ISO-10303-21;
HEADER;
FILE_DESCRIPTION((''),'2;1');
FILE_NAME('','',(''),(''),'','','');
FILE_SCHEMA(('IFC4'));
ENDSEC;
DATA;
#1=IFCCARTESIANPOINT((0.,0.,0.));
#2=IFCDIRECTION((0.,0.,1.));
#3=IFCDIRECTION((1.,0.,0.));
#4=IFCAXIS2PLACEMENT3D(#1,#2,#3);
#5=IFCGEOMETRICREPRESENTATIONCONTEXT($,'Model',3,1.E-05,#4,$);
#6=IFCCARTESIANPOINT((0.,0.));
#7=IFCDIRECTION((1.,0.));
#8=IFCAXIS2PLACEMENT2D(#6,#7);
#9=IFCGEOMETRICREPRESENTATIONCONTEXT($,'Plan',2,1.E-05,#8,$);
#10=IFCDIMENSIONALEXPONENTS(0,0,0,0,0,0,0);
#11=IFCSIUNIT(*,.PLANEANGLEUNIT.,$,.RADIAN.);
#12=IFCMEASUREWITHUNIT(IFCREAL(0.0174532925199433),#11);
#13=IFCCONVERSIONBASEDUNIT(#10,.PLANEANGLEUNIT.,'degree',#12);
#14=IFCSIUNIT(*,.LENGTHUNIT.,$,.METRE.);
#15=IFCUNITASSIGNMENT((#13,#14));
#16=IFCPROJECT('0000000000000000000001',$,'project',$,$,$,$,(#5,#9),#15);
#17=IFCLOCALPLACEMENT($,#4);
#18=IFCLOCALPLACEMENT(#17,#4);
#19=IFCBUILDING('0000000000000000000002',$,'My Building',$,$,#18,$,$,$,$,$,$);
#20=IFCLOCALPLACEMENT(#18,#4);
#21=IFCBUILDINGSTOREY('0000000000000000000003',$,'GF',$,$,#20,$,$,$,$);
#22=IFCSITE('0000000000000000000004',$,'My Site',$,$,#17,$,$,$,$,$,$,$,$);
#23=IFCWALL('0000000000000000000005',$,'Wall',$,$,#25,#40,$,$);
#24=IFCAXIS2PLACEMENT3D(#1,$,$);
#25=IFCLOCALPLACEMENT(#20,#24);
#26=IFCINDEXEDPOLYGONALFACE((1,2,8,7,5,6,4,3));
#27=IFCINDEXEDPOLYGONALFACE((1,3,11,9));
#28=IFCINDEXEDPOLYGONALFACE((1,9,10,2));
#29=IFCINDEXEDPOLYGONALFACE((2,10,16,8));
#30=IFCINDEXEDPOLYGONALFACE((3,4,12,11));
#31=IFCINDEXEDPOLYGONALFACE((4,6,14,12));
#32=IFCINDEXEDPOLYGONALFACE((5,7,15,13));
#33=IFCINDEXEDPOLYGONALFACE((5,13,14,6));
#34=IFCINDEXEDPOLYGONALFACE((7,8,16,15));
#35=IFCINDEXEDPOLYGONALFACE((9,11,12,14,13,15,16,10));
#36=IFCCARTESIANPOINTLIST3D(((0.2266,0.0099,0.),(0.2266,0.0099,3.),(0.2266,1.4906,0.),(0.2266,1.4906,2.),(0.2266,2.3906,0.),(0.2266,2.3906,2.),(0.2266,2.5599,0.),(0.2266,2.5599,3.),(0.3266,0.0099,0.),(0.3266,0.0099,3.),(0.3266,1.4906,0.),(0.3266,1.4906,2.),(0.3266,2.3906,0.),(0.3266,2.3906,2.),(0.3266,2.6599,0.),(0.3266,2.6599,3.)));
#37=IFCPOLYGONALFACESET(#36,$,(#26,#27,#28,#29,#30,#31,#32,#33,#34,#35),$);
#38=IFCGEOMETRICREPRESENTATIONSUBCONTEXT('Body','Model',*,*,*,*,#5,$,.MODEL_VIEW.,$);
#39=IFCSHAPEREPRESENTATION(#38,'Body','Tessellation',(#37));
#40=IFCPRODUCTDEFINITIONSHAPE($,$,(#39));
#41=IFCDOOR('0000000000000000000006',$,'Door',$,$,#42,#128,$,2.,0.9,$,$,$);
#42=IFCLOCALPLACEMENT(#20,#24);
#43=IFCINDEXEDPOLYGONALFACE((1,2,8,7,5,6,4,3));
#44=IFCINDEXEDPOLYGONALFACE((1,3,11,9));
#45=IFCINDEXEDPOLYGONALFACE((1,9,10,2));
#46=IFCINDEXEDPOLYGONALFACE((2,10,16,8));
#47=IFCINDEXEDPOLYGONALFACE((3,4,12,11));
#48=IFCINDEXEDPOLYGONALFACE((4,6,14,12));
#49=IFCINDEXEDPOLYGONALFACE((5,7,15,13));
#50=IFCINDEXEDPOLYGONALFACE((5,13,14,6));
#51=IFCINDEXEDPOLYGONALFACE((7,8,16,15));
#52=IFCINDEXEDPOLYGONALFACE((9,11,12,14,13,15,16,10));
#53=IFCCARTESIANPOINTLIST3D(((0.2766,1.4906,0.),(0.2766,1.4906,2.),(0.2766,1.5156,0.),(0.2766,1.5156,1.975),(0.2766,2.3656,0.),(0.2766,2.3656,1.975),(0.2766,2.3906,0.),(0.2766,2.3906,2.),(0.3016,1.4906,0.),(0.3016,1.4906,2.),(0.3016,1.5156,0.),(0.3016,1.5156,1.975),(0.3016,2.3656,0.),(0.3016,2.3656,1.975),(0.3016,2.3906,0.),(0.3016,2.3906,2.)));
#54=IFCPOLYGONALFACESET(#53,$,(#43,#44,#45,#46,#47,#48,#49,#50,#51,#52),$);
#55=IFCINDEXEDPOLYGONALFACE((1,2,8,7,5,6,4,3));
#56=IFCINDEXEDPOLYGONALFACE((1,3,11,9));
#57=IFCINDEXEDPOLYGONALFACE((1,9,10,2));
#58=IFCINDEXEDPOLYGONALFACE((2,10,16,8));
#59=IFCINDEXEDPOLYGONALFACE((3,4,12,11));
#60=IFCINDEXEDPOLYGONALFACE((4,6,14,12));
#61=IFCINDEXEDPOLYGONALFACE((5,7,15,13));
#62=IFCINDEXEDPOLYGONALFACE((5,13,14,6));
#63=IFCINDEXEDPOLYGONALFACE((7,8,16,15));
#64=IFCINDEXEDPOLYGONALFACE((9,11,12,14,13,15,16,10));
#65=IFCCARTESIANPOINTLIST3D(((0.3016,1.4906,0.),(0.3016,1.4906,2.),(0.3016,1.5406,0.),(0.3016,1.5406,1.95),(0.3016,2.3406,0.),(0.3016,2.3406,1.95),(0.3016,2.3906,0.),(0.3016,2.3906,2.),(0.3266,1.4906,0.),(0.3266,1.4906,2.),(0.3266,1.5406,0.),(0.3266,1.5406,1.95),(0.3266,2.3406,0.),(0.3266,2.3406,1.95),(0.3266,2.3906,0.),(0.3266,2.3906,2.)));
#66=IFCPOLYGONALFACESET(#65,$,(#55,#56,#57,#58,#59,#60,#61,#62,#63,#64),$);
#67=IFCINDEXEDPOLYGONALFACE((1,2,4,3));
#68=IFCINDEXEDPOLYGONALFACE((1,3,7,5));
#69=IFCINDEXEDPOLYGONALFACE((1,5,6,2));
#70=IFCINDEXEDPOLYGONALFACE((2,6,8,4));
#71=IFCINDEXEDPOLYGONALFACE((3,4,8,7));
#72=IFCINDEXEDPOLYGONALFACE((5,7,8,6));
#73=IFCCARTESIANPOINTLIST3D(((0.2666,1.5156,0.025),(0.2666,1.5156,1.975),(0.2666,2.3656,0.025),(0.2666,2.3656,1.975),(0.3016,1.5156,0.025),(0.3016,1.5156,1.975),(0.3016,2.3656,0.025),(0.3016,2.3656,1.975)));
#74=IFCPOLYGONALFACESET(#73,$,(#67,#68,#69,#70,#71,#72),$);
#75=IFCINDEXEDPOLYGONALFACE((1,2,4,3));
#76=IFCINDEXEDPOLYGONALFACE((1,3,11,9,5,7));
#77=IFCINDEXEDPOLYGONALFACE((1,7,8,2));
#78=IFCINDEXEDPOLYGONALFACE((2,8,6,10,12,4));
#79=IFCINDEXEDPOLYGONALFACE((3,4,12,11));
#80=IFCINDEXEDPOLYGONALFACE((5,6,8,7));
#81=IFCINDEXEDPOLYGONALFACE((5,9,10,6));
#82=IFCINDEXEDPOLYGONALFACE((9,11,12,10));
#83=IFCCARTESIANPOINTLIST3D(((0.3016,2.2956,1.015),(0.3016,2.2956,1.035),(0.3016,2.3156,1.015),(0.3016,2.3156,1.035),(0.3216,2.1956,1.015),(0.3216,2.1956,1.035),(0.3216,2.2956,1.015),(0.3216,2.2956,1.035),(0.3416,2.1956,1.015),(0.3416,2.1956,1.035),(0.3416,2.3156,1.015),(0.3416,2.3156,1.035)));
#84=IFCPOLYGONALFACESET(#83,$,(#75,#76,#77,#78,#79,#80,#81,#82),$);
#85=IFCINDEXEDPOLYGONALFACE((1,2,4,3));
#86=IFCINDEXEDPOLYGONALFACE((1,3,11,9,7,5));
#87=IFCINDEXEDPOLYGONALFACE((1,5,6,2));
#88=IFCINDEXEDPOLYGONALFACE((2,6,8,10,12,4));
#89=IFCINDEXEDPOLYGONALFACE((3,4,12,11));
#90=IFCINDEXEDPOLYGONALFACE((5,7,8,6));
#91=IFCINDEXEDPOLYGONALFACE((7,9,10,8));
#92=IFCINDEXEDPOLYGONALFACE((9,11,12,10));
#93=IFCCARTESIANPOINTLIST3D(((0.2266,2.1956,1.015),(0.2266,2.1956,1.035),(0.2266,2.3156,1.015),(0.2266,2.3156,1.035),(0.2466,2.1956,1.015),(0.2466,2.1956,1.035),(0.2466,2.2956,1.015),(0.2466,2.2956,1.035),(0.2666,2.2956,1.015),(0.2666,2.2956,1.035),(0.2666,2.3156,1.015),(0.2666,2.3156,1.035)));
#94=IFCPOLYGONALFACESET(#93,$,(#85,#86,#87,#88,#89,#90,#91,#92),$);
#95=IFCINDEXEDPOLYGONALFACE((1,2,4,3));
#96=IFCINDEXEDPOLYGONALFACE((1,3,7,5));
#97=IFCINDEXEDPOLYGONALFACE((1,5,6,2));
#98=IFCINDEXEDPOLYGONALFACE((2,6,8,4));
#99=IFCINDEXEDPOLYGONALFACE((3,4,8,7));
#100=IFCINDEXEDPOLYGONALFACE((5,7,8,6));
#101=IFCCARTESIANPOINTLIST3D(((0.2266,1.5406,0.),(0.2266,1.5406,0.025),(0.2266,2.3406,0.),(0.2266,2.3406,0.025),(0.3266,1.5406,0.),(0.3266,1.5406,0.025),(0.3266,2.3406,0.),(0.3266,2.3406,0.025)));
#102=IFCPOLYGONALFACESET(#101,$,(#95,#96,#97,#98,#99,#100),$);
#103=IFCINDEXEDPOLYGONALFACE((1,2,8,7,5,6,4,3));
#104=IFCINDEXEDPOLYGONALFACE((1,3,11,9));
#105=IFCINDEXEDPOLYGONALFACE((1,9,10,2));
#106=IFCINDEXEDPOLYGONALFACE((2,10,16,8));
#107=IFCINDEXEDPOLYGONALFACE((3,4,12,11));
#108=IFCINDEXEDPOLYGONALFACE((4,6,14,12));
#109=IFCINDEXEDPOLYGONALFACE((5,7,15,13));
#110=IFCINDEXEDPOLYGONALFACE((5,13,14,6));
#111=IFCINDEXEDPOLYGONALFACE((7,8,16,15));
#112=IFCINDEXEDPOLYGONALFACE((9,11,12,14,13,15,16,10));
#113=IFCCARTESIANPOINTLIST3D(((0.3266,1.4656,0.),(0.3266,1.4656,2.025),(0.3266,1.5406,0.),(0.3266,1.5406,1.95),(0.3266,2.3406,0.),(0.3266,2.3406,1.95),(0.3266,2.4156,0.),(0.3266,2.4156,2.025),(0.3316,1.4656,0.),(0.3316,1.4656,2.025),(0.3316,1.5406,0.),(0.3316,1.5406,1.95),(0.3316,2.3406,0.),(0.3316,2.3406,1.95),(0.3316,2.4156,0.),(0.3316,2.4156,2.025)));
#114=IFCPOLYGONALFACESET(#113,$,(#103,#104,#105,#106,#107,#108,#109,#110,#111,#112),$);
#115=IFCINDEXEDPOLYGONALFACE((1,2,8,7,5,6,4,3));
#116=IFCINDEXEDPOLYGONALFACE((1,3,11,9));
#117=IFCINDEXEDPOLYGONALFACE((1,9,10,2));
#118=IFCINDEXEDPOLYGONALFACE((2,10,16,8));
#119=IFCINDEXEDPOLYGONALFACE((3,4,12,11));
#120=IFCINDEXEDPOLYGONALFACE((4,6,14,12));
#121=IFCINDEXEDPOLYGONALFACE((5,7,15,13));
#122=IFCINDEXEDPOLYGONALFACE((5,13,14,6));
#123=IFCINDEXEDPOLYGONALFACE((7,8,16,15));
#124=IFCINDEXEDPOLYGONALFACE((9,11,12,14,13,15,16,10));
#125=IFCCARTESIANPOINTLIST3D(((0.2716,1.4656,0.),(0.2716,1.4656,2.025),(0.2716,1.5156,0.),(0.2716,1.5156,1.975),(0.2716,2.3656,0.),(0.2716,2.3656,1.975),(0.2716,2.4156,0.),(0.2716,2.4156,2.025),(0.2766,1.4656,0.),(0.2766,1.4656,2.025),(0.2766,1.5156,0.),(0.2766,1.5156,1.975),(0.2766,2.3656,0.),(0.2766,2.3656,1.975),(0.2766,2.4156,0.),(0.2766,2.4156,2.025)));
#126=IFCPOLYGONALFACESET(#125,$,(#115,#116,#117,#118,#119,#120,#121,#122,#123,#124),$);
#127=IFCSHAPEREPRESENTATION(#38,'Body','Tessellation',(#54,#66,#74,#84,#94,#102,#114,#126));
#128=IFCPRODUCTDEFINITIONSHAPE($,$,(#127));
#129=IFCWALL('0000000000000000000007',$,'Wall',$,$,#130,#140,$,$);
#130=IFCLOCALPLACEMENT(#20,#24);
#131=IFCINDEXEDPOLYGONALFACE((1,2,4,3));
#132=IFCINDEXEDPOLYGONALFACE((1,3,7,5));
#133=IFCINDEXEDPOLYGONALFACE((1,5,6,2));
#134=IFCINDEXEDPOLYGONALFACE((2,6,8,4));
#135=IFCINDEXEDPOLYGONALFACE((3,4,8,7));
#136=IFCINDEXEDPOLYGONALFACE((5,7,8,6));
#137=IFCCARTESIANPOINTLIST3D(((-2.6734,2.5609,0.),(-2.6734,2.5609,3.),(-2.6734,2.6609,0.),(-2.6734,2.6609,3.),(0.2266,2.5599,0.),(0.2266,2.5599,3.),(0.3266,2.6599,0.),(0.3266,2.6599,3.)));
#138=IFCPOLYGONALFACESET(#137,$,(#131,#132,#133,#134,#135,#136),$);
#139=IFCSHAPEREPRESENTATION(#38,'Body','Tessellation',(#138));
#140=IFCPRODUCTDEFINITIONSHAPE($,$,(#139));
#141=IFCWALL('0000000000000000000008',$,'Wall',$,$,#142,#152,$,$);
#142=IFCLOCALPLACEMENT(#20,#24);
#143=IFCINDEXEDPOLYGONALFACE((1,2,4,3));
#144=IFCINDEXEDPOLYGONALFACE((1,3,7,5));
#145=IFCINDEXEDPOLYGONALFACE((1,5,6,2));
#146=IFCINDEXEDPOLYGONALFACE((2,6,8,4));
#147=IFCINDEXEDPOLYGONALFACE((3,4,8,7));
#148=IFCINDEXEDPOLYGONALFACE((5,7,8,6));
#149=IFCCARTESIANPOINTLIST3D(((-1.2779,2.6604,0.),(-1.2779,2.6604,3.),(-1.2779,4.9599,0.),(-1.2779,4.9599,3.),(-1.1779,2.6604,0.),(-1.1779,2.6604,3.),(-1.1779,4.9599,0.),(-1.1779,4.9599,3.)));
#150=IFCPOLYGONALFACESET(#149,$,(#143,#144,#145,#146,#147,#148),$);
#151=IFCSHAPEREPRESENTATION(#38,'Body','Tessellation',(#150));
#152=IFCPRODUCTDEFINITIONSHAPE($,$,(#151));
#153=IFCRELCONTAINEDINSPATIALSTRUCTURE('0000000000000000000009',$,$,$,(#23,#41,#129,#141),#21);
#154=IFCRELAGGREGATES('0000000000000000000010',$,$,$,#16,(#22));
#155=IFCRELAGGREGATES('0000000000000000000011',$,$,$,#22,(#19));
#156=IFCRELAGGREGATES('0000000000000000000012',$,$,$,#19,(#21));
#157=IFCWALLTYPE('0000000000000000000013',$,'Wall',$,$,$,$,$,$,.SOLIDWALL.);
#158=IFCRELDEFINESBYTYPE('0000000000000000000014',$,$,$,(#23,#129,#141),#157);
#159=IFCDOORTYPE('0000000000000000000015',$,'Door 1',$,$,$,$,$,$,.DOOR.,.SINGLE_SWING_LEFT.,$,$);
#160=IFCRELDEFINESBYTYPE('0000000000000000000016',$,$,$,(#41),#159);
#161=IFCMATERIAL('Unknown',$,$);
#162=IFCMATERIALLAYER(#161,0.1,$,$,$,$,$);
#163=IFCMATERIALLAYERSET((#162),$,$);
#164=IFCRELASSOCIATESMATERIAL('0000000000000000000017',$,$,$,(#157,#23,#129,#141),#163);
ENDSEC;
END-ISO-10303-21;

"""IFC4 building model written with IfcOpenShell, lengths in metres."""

from ifc_helpers import new_model, entity, si_unit, converted_unit, frame, origin_with_axes, origin_2d_with_axis, place, context, subcontext, project, spatial, line, indexed_curve, outline, extrude, shape, source, transform, mapped, material, layer, layer_set, layer_usage, type_object, type_shapes, element, fill, save


model = new_model("IFC4")

# Units and contexts
model_context = context("Model", 3, precision=1e-05, world=origin_with_axes())
plan_context = context("Plan", 2, precision=1e-05, world=origin_2d_with_axis())
body_context_1 = subcontext(model_context, "Body", "Model", "MODEL_VIEW")
body_context_2 = subcontext(plan_context, "Body", "Plan", "PLAN_VIEW")
ifc_project = project(units=[converted_unit("PLANEANGLEUNIT", "degree", entity("IfcReal", 0.0174532925199433), si_unit("PLANEANGLEUNIT", "RADIAN"), dimensions=[0, 0, 0, 0, 0, 0, 0]), si_unit("LENGTHUNIT", "METRE")], contexts=[model_context, plan_context])

# Site, building, storey
site_placement = place(None, origin_with_axes())
site = spatial("IfcSite", under=ifc_project, at=site_placement, Name="My Site")
building_placement = place(site_placement, origin_with_axes())
building = spatial("IfcBuilding", under=site, at=building_placement, Name="My Building")
storey_placement = place(building_placement, origin_with_axes())
storey = spatial("IfcBuildingStorey", under=building, at=storey_placement, Name="GF")

# Shared definitions
ifc_material_1 = material(Name="Unknown")

# Shared definitions
ifc_layer_1 = layer(ifc_material_1, 0.1)
ifc_layer_set_1 = layer_set([ifc_layer_1])
wall_type = type_object("IfcWallType", Name="Wall", PredefinedType="SOLIDWALL", material=ifc_layer_set_1)
shared_shape_1 = source(origin_with_axes(), body_context_1, "Body", "SweptSolid", [
    extrude(outline(indexed_curve([(0.0, 0.0), (0.9, 0.0), (0.9, 2.0), (0.0, 2.0)], segments=[line(1, 2, 3, 4, 1)])), frame((0.0, -0.6, 0.0), z_axis=(0.0, -1.0, 0.0), x_axis=(1.0, 0.0, 0.0)), (0.0, 0.0, -1.0), 1.2),
])
door_type = type_object("IfcDoorType", Name="Door 1", OperationType="SINGLE_SWING_LEFT", PredefinedType="DOOR")
shared_shape_2 = source(origin_with_axes(), body_context_1, "Body", "SweptSolid", [
    extrude(outline(indexed_curve([(0.0, 0.0), (0.0, 2.0), (0.9, 2.0), (0.9, 0.0), (0.875, 0.0), (0.875, 1.975), (0.025, 1.975), (0.025, 0.0)], segments=[line(1, 2, 3, 4, 5, 6, 7, 8, 1)])), frame((0.0, 0.025, 0.0), z_axis=(0.0, -1.0, 0.0), x_axis=(1.0, 0.0, 0.0)), (0.0, 0.0, -1.0), 0.025),
    extrude(outline(indexed_curve([(0.0, 0.0), (0.0, 2.0), (0.9, 2.0), (0.9, 0.0), (0.85, 0.0), (0.85, 1.95), (0.05, 1.95), (0.05, 0.0)], segments=[line(1, 2, 3, 4, 5, 6, 7, 8, 1)])), frame((0.0, 0.0, 0.0), z_axis=(0.0, -1.0, 0.0), x_axis=(1.0, 0.0, 0.0)), (0.0, 0.0, -1.0), 0.025),
    extrude(outline(indexed_curve([(0.0, 0.0), (0.85, 0.0), (0.85, 0.035), (0.0, 0.035)], segments=[line(1, 2, 3, 4, 1)])), frame((0.025, 0.025, 0.025), z_axis=(0.0, 0.0, 1.0), x_axis=(1.0, 0.0, 0.0)), (0.0, 0.0, 1.0), 1.95),
    extrude(outline(indexed_curve([(0.0, 0.0), (0.0, -0.04), (-0.12, -0.04), (-0.12, -0.02), (-0.02, -0.02), (-0.02, 0.0)], segments=[line(1, 2, 3, 4, 5, 6, 1)])), frame((0.825, 0.025, 1.015), z_axis=(0.0, 0.0, 1.0), x_axis=(1.0, 0.0, 0.0)), (0.0, 0.0, 1.0), 0.02),
    extrude(outline(indexed_curve([(0.0, 0.0), (0.0, 0.04), (-0.12, 0.04), (-0.12, 0.02), (-0.02, 0.02), (-0.02, 0.0)], segments=[line(1, 2, 3, 4, 5, 6, 1)])), frame((0.825, 0.06, 1.015), z_axis=(0.0, 0.0, 1.0), x_axis=(1.0, 0.0, 0.0)), (0.0, 0.0, 1.0), 0.02),
    extrude(outline(indexed_curve([(0.0, 0.0), (0.8, 0.0), (0.8, 0.1), (0.0, 0.1)], segments=[line(1, 2, 3, 4, 1)])), frame((0.05, 0.0, 0.0), z_axis=(0.0, 0.0, 1.0), x_axis=(1.0, 0.0, 0.0)), (0.0, 0.0, 1.0), 0.025),
    extrude(outline(indexed_curve([(0.0, 0.0), (0.0, 2.025), (0.95, 2.025), (0.95, 0.0), (0.875, 0.0), (0.875, 1.95), (0.075, 1.95), (0.075, 0.0)], segments=[line(1, 2, 3, 4, 5, 6, 7, 8, 1)])), frame((-0.025, -0.005, 0.0), z_axis=(0.0, -1.0, 0.0), x_axis=(1.0, 0.0, 0.0)), (0.0, 0.0, -1.0), 0.005),
    extrude(outline(indexed_curve([(0.0, 0.0), (0.0, 2.025), (0.95, 2.025), (0.95, 0.0), (0.9, 0.0), (0.9, 1.975), (0.05, 1.975), (0.05, 0.0)], segments=[line(1, 2, 3, 4, 5, 6, 7, 8, 1)])), frame((-0.025, 0.05, 0.0), z_axis=(0.0, -1.0, 0.0), x_axis=(1.0, 0.0, 0.0)), (0.0, 0.0, -1.0), 0.005),
])
shared_shape_3 = source(origin_with_axes(), body_context_2, "Body", "Curve2D", [
    entity("IfcIndexedPolyCurve", entity("IfcCartesianPointList2D", [[0.0, 0.0], [0.0, 0.05], [0.025, 0.05], [0.025, 0.025], [0.05, 0.025], [0.05, 0.0]]), [entity("IfcLineIndex", [1, 2, 3, 4, 5, 6, 1])]),
    entity("IfcIndexedPolyCurve", entity("IfcCartesianPointList2D", [[0.9, 0.0], [0.9, 0.05], [0.875, 0.05], [0.875, 0.025], [0.85, 0.025], [0.85, 0.0]]), [entity("IfcLineIndex", [1, 2, 3, 4, 5, 6, 1])]),
    entity("IfcTrimmedCurve", entity("IfcEllipse", entity("IfcAxis2Placement2D", entity("IfcCartesianPoint", [0.06, 0.05]), entity("IfcDirection", [1.0, 0.0])), 0.815, 0.85), [entity("IfcCartesianPoint", [0.875, 0.05])], [entity("IfcCartesianPoint", [0.06, 0.9])], True, "CARTESIAN"),
    entity("IfcIndexedPolyCurve", entity("IfcCartesianPointList2D", [[0.025, 0.05], [0.06, 0.05], [0.06, 0.9], [0.025, 0.9]]), [entity("IfcLineIndex", [1, 2, 3, 4, 1])]),
])
type_shapes(door_type, [shared_shape_2, shared_shape_3])

# Wall, opening, door
ifc_layer_usage_1 = layer_usage(ifc_layer_set_1, "AXIS2", "POSITIVE", 0.0)
wall_1_placement = place(storey_placement, frame((0.3266, 0.0099, 0.0), z_axis=(0.0, 0.0, 1.0), x_axis=(0.0, 1.0, 0.0)))
wall_1 = element("IfcWall", 1, at=wall_1_placement, inside=storey, type_object=wall_type, material=ifc_layer_usage_1, Name="Wall", context=body_context_1, shape_type="SweptSolid", body=[
    extrude(outline(indexed_curve([(0.0, 0.0), (0.0, 0.1), (2.55, 0.1), (2.65, 0.0)], segments=[line(1, 2, 3, 4, 1)])), origin_with_axes(), (0.0, 0.0, 1.0), 3.0),
])
opening_1_placement = place(wall_1_placement, frame((1.4807, 0.0, 0.0), z_axis=(0.0, 0.0, 1.0), x_axis=(1.0, 0.0, 0.0)))
opening_1 = element("IfcOpeningElement", 2, at=opening_1_placement, cuts=wall_1, PredefinedType="OPENING", context=body_context_1, shape_type="MappedRepresentation", body=[
    mapped(shared_shape_1, transform((0.0, 0.0, 0.0), x_axis=(1.0, 0.0, 0.0), y_axis=(0.0, 1.0, 0.0), z_axis=(0.0, 0.0, 1.0), scale=1.0)),
])
door_1_placement = place(opening_1_placement, frame((0.0, 0.0, 0.0), z_axis=(0.0, 0.0, 1.0), x_axis=(1.0, 0.0, 0.0)))
door_1 = element("IfcDoor", 3, at=door_1_placement, inside=storey, type_object=door_type, Name="Door", OverallHeight=2.0, OverallWidth=0.9, shapes=[
    shape(body_context_1, "Body", "MappedRepresentation", [mapped(shared_shape_2, transform((0.0, 0.0, 0.0), x_axis=(1.0, 0.0, 0.0), y_axis=(0.0, 1.0, 0.0), z_axis=(0.0, 0.0, 1.0), scale=1.0))]),
    shape(body_context_2, "Body", "MappedRepresentation", [mapped(shared_shape_3, transform((0.0, 0.0, 0.0), x_axis=(1.0, 0.0, 0.0), y_axis=(0.0, 1.0, 0.0), z_axis=(0.0, 0.0, 1.0), scale=1.0))]),
])
fill(opening_1, door_1)

# Walls
ifc_layer_usage_2 = layer_usage(ifc_layer_set_1, "AXIS2", "POSITIVE", 0.0)
wall_2_placement = place(storey_placement, frame((0.3266, 2.6599, 0.0), z_axis=(0.0, 0.0, 1.0), x_axis=(-1.0, 0.00034, 0.0)))
element("IfcWall", 4, at=wall_2_placement, inside=storey, type_object=wall_type, material=ifc_layer_usage_2, Name="Wall", context=body_context_1, shape_type="SweptSolid", body=[
    extrude(outline(indexed_curve([(0.0, 0.0), (0.1, 0.1), (3.0, 0.1), (3.0, 0.0)], segments=[line(1, 2, 3, 4, 1)])), origin_with_axes(), (0.0, 0.0, 1.0), 3.0),
])
ifc_layer_usage_3 = layer_usage(ifc_layer_set_1, "AXIS2", "POSITIVE", 0.0)
wall_3_placement = place(storey_placement, frame((-1.2779, 4.9599, 0.0), z_axis=(0.0, 0.0, 1.0), x_axis=(0.0, -1.0, 0.0)))
element("IfcWall", 5, at=wall_3_placement, inside=storey, type_object=wall_type, material=ifc_layer_usage_3, Name="Wall", context=body_context_1, shape_type="SweptSolid", body=[
    extrude(outline(indexed_curve([(0.0, 0.0), (0.0, 0.1), (2.2995, 0.1), (2.2995, 0.0)], segments=[line(1, 2, 3, 4, 1)])), origin_with_axes(), (0.0, 0.0, 1.0), 3.0),
])

save(model, "model.ifc")
